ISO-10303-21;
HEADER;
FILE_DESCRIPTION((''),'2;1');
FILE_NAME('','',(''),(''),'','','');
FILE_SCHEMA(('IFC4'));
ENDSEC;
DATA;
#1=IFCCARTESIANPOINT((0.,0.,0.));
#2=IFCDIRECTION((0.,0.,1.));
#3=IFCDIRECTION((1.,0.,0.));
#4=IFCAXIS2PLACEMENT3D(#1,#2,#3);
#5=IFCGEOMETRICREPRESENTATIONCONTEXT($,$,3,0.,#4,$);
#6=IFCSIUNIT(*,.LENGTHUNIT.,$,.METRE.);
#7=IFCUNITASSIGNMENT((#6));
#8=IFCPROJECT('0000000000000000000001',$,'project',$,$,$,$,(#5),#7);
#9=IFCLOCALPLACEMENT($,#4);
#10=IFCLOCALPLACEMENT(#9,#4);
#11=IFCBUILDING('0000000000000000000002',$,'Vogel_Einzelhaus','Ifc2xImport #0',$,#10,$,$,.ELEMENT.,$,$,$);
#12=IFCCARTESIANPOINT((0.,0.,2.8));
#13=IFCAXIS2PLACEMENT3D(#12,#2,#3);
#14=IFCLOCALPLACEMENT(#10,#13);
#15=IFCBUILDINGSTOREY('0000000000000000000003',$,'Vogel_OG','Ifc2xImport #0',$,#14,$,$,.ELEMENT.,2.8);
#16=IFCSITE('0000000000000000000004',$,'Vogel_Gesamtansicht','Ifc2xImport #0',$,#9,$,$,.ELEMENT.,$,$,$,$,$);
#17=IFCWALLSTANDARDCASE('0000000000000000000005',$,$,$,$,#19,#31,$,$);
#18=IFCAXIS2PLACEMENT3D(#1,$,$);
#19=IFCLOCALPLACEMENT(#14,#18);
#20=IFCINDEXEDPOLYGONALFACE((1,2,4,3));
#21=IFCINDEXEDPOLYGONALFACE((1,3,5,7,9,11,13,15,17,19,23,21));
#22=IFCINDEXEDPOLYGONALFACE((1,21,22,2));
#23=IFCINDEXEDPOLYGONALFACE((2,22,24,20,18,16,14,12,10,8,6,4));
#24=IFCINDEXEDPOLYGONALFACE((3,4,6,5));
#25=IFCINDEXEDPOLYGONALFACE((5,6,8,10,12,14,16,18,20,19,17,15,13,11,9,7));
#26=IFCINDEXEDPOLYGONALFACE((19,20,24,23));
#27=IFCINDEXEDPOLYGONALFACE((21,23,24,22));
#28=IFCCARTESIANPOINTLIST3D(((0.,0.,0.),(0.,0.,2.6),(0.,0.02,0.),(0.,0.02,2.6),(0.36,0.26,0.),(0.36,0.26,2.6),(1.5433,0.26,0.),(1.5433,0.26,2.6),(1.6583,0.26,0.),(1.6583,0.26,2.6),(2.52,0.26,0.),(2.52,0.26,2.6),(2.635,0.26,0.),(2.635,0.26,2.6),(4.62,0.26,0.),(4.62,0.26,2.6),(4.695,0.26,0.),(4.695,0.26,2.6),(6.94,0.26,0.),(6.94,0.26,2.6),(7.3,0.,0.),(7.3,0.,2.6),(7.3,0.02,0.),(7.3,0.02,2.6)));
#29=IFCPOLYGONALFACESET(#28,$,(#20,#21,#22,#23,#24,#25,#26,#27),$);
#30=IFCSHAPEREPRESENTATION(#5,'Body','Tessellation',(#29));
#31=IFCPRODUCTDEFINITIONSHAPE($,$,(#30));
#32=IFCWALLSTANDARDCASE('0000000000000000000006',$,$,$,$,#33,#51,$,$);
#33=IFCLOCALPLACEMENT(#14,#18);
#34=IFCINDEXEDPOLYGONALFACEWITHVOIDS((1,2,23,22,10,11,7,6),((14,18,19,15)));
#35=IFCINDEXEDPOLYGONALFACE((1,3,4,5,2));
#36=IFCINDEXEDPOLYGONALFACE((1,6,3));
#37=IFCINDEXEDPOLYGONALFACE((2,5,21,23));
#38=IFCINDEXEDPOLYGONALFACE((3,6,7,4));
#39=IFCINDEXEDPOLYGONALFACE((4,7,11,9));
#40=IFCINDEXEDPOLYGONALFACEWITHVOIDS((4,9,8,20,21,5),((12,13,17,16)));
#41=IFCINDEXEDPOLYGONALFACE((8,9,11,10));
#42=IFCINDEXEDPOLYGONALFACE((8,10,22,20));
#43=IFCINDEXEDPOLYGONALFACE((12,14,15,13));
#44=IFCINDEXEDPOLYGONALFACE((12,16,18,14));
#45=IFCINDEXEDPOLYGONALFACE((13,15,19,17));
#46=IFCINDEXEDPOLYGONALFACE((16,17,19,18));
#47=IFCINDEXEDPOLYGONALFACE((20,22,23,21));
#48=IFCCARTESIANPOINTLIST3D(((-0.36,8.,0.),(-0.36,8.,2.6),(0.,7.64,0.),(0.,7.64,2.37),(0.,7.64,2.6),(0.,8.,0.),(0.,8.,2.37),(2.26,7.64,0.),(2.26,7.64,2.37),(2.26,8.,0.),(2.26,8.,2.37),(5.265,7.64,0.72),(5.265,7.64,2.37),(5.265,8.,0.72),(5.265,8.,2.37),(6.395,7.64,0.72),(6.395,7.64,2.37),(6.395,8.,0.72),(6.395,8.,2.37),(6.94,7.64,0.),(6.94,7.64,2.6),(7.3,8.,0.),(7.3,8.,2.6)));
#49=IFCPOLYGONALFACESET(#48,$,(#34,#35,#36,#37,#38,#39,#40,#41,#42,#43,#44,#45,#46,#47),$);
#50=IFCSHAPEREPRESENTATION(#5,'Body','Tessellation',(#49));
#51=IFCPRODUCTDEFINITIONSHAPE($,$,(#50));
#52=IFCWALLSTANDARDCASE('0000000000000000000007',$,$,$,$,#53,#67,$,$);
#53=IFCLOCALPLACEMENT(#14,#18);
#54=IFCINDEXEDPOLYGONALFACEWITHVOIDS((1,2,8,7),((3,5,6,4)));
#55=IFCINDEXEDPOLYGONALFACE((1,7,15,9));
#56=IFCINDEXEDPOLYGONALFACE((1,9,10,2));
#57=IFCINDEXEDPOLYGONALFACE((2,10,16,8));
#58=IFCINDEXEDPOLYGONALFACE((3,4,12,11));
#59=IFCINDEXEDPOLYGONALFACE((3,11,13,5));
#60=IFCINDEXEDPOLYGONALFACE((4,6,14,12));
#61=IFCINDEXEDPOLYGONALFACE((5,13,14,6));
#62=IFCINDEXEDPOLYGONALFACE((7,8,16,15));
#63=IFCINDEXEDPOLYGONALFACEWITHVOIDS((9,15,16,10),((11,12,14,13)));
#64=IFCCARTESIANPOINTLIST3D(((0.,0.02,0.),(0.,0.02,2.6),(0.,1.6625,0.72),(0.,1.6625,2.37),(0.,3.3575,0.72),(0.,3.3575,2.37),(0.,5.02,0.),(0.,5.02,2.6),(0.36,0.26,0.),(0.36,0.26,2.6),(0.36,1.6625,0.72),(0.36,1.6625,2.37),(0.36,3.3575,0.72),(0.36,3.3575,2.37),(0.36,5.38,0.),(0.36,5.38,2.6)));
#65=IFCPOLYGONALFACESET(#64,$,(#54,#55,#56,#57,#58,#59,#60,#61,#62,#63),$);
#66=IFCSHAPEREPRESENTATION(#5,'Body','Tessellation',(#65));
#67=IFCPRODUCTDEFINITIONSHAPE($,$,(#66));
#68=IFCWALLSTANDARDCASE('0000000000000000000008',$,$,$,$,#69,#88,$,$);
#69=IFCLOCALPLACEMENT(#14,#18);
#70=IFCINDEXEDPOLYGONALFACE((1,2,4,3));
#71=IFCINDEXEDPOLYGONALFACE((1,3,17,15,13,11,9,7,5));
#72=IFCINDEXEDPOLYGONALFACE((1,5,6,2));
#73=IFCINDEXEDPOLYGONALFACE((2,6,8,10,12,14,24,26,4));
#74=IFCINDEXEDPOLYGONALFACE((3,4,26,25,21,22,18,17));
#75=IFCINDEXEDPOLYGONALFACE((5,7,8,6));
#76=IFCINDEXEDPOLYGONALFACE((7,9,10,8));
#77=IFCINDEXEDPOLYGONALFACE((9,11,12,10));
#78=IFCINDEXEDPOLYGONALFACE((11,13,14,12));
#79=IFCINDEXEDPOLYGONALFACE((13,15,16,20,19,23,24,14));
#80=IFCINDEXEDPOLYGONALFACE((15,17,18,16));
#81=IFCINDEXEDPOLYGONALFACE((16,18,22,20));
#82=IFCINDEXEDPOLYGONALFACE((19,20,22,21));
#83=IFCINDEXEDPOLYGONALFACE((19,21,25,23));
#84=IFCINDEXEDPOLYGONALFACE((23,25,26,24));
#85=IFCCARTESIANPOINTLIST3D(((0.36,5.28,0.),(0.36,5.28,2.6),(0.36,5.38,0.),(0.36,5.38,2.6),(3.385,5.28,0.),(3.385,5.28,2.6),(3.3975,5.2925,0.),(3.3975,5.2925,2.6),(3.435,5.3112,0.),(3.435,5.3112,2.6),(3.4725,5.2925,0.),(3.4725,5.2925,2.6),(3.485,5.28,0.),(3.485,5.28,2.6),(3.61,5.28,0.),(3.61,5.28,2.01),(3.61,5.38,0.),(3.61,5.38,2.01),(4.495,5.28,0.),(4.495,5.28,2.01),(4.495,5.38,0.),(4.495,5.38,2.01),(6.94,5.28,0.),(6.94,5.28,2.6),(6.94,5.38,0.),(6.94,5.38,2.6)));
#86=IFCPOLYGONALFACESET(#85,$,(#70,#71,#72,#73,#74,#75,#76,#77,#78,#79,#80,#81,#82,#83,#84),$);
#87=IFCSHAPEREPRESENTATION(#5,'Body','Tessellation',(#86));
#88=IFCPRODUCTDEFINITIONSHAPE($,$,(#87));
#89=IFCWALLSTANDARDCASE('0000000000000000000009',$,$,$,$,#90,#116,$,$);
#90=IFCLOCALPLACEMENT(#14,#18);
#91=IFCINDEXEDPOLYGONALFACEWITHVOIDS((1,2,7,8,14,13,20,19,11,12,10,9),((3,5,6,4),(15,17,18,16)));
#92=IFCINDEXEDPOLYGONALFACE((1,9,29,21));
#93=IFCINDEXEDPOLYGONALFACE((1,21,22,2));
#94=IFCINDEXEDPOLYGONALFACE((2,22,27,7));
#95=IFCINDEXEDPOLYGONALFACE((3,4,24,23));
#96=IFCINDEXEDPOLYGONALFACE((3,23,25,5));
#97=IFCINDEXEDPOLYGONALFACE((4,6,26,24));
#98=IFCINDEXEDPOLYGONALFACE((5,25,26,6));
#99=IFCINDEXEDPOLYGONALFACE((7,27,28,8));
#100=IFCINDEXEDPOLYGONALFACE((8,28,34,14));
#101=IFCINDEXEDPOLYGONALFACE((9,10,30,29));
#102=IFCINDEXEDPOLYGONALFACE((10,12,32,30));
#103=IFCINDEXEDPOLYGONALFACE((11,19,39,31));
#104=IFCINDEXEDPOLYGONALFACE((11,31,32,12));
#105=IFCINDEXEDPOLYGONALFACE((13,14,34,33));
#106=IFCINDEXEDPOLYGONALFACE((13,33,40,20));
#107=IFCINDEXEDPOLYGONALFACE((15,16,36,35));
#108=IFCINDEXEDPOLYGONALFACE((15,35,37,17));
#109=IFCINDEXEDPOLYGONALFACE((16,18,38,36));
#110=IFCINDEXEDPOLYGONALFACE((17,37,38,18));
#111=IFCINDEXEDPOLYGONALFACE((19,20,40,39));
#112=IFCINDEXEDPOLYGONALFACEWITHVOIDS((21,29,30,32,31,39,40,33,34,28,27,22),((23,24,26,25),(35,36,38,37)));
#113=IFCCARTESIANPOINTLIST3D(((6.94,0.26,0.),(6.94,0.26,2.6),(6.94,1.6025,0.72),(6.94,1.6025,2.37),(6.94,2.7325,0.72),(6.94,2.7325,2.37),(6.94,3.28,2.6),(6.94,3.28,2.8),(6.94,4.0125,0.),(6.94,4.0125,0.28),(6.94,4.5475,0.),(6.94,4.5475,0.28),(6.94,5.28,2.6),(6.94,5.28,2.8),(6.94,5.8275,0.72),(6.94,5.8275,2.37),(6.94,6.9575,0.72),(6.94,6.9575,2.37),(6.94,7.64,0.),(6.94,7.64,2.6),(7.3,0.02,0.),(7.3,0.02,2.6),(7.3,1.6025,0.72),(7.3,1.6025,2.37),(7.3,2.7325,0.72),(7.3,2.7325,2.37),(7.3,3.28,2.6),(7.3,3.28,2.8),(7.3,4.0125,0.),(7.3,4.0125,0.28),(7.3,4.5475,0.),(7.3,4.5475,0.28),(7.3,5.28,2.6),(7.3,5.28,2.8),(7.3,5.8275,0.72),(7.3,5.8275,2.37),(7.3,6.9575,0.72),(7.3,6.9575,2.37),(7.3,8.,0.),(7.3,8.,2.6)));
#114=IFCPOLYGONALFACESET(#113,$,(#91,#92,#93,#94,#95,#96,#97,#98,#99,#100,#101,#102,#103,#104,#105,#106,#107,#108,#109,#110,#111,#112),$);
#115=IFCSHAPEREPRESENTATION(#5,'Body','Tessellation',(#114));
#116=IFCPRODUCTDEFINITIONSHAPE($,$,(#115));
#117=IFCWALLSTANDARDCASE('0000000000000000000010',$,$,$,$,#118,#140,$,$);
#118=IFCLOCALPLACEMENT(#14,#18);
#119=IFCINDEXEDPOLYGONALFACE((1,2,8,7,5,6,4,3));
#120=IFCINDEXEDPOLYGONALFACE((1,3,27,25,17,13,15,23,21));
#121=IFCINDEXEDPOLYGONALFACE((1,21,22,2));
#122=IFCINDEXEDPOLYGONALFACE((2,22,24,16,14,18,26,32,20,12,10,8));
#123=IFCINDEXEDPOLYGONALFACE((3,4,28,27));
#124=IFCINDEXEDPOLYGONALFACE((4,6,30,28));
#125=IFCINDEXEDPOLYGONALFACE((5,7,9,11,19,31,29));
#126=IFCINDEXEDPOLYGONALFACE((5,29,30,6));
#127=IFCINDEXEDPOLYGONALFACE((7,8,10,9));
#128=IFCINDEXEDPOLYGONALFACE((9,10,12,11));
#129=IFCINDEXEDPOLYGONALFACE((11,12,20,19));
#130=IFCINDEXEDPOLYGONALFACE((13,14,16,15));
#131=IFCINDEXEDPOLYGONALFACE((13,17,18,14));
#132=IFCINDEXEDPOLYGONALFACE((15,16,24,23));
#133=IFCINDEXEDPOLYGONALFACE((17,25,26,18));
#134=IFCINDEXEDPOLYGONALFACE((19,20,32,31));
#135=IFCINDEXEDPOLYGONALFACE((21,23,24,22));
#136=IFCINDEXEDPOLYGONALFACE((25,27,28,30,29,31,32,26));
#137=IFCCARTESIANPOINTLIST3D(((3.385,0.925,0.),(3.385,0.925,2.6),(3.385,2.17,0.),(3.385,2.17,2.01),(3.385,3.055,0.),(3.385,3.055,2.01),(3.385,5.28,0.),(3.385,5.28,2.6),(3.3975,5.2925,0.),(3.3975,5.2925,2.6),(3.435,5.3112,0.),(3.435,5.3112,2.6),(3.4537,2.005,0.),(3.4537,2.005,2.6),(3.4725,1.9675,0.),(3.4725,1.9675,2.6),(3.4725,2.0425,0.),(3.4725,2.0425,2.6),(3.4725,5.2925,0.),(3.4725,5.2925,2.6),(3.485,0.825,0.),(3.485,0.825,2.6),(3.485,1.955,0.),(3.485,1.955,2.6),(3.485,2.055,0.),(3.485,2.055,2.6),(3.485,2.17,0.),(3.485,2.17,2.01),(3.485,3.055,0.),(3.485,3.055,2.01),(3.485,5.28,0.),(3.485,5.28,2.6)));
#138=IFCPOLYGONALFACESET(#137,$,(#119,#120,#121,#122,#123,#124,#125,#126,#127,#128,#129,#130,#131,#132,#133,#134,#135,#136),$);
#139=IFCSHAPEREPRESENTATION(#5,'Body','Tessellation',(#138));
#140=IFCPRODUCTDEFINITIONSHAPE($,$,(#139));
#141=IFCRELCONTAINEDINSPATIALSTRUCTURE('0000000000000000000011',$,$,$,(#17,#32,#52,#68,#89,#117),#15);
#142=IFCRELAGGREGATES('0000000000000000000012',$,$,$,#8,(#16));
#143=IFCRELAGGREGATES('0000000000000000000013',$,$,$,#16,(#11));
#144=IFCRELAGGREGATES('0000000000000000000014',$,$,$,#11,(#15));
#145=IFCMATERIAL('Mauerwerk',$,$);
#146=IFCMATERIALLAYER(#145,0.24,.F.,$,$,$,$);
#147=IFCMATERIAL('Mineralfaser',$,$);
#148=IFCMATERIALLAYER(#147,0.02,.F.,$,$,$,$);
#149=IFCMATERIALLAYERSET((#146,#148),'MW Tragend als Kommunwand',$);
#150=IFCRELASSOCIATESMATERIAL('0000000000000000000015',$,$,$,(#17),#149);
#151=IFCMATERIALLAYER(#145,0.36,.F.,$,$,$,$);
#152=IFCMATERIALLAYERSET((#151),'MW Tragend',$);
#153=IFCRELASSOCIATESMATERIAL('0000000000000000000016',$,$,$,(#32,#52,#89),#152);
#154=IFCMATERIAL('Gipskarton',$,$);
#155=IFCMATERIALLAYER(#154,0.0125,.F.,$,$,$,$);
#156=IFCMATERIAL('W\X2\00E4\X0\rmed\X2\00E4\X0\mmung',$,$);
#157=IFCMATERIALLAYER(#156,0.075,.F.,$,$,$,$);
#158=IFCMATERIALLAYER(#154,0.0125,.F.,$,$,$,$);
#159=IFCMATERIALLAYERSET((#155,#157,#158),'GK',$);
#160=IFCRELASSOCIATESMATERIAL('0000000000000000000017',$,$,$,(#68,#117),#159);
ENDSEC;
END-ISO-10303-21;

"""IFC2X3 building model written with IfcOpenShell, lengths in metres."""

from ifc_helpers import new_model, si_unit, frame, origin_with_axes, origin_2d_with_axis, place, context, project, spatial, polyline, rectangle, outline, extrude, clip, bounded_halfspace, shape, material, layer, layer_set, layer_usage, element, save


model = new_model("IFC2X3")

# Units and contexts
context_of_model = context(None, 3, precision=0.0, world=origin_with_axes())
ifc_project = project(units=[si_unit("LENGTHUNIT", "METRE")], contexts=[context_of_model])

# Site, building, storey
site_placement = place(None, origin_with_axes())
site = spatial("IfcSite", under=ifc_project, at=site_placement, Name="Vogel_Gesamtansicht", Description="Ifc2xImport #0", CompositionType="ELEMENT")
building_placement = place(site_placement, origin_with_axes())
building = spatial("IfcBuilding", under=site, at=building_placement, Name="Vogel_Einzelhaus", Description="Ifc2xImport #0", CompositionType="ELEMENT")
storey_placement = place(building_placement, frame((0.0, 0.0, 2.8), z_axis=(0.0, 0.0, 1.0), x_axis=(1.0, 0.0, 0.0)))
storey = spatial("IfcBuildingStorey", under=building, at=storey_placement, Name="Vogel_OG", Description="Ifc2xImport #0", CompositionType="ELEMENT", Elevation=2.8)

# Wall
ifc_material_1 = material(Name="Mauerwerk")
ifc_layer_1 = layer(ifc_material_1, 0.24, ventilated=False)
ifc_material_2 = material(Name="Mineralfaser")
ifc_layer_2 = layer(ifc_material_2, 0.02, ventilated=False)
ifc_layer_set_1 = layer_set([ifc_layer_1, ifc_layer_2], Name="MW Tragend als Kommunwand")
ifc_layer_usage_1 = layer_usage(ifc_layer_set_1, "AXIS2", "POSITIVE", -0.26)
wall_1_placement = place(storey_placement, frame((7.3, 0.0, 0.0), z_axis=(0.0, 0.0, 1.0), x_axis=(-1.0, 0.0, 0.0)))
element("IfcWallStandardCase", 1, at=wall_1_placement, inside=storey, material=ifc_layer_usage_1, context=context_of_model, shape_type="SweptSolid", body=[
    extrude(outline(polyline([(0.0, -0.02), (0.36, -0.26), (2.605, -0.26), (2.68, -0.26), (4.665, -0.26), (4.78, -0.26), (5.6417, -0.26), (5.7567, -0.26), (6.94, -0.26), (7.3, -0.02), (7.3, 0.0), (0.0, 0.0), (0.0, -0.02)])), origin_with_axes(), (0.0, 0.0, 1.0), 2.6),
])

# Wall, openings
ifc_layer_3 = layer(ifc_material_1, 0.36, ventilated=False)
ifc_layer_set_2 = layer_set([ifc_layer_3], Name="MW Tragend")
ifc_layer_usage_2 = layer_usage(ifc_layer_set_2, "AXIS2", "POSITIVE", -0.36)
wall_2_placement = place(storey_placement, frame((-0.18, 8.0, 0.0), z_axis=(0.0, 0.0, 1.0), x_axis=(1.0, 0.0, 0.0)))
wall_2 = element("IfcWallStandardCase", 2, at=wall_2_placement, inside=storey, material=ifc_layer_usage_2, context=context_of_model, shape_type="SweptSolid", body=[
    extrude(outline(polyline([(-0.18, 0.0), (0.18, -0.36), (7.12, -0.36), (7.48, 0.0), (-0.18, 0.0)])), origin_with_axes(), (0.0, 0.0, 1.0), 2.6),
])
opening_1_placement = place(wall_2_placement, frame((0.18, 0.0, 0.0), z_axis=(1.0, 0.0, 0.0), x_axis=(0.0, 0.0, 1.0)))
element("IfcOpeningElement", 3, at=opening_1_placement, cuts=wall_2, shapes=[
    shape(context_of_model, None, "SweptSolid", [extrude(rectangle(XDim=2.37, YDim=2.26, at=origin_2d_with_axis()), frame((1.185, 0.0, 1.13), z_axis=(0.0, 1.0, 0.0), x_axis=(1.0, 0.0, 0.0)), (0.0, 0.0, 1.0), 0.36)]),
])
opening_2_placement = place(wall_2_placement, frame((6.575, -0.36, 0.72), z_axis=(-1.0, 0.0, 0.0), x_axis=(0.0, 0.0, 1.0)))
element("IfcOpeningElement", 4, at=opening_2_placement, cuts=wall_2, shapes=[
    shape(context_of_model, None, "SweptSolid", [extrude(rectangle(XDim=1.65, YDim=1.13, at=origin_2d_with_axis()), frame((0.825, 0.0, 0.565), z_axis=(0.0, 1.0, 0.0), x_axis=(1.0, 0.0, 0.0)), (0.0, 0.0, 1.0), 0.36)]),
])

# Wall, opening
wall_3_placement = place(storey_placement, frame((0.0, 0.0, 0.0), z_axis=(0.0, 0.0, 1.0), x_axis=(0.0, 1.0, 0.0)))
wall_3 = element("IfcWallStandardCase", 5, at=wall_3_placement, inside=storey, material=ifc_layer_usage_2, context=context_of_model, shape_type="SweptSolid", body=[
    extrude(outline(polyline([(5.38, -0.36), (5.02, 0.0), (0.02, 0.0), (0.26, -0.36), (5.28, -0.36), (5.38, -0.36)])), origin_with_axes(), (0.0, 0.0, 1.0), 2.6),
])
opening_3_placement = place(wall_3_placement, frame((1.6625, 0.0, 0.72), z_axis=(1.0, 0.0, 0.0), x_axis=(0.0, 0.0, 1.0)))
element("IfcOpeningElement", 6, at=opening_3_placement, cuts=wall_3, shapes=[
    shape(context_of_model, None, "SweptSolid", [extrude(rectangle(XDim=1.65, YDim=1.695, at=origin_2d_with_axis()), frame((0.825, 0.0, 0.8475), z_axis=(0.0, 1.0, 0.0), x_axis=(1.0, 0.0, 0.0)), (0.0, 0.0, 1.0), 0.36)]),
])

# Shared definitions
ifc_material_3 = material(Name="Gipskarton")
ifc_layer_4 = layer(ifc_material_3, 0.0125, ventilated=False)
ifc_material_4 = material(Name="Wärmedämmung")
ifc_layer_5 = layer(ifc_material_4, 0.075, ventilated=False)
ifc_layer_6 = layer(ifc_material_3, 0.0125, ventilated=False)
ifc_layer_set_3 = layer_set([ifc_layer_4, ifc_layer_5, ifc_layer_6], Name="GK")
ifc_layer_usage_3 = layer_usage(ifc_layer_set_3, "AXIS2", "POSITIVE", -0.1)

# Wall, opening
ifc_layer_usage_4 = layer_usage(ifc_layer_set_3, "AXIS2", "POSITIVE", 0.0)
wall_4_placement = place(storey_placement, frame((0.36, 5.28, 0.0), z_axis=(0.0, 0.0, 1.0), x_axis=(1.0, 0.0, 0.0)))
wall_4 = element("IfcWallStandardCase", 7, at=wall_4_placement, inside=storey, material=ifc_layer_usage_4, context=context_of_model, shape_type="SweptSolid", body=[
    extrude(outline(polyline([(3.025, 0.0), (3.0375, 0.0125), (3.075, 0.0313), (3.1125, 0.0125), (3.125, 0.0), (6.58, 0.0), (6.58, 0.1), (0.0, 0.1), (0.0, 0.0), (3.025, 0.0)])), origin_with_axes(), (0.0, 0.0, 1.0), 2.6),
])
opening_4_placement = place(wall_4_placement, frame((3.25, 0.1, 0.0), z_axis=(1.0, 0.0, 0.0), x_axis=(0.0, 0.0, 1.0)))
element("IfcOpeningElement", 8, at=opening_4_placement, cuts=wall_4, shapes=[
    shape(context_of_model, None, "SweptSolid", [extrude(rectangle(XDim=2.01, YDim=0.885, at=origin_2d_with_axis()), frame((1.005, 0.0, 0.4425), z_axis=(0.0, 1.0, 0.0), x_axis=(1.0, 0.0, 0.0)), (0.0, 0.0, 1.0), 0.1)]),
])

# Wall, openings
wall_5_placement = place(storey_placement, frame((7.3, 8.0, 0.0), z_axis=(0.0, 0.0, 1.0), x_axis=(0.0, -1.0, 0.0)))
wall_5 = element("IfcWallStandardCase", 9, at=wall_5_placement, inside=storey, material=ifc_layer_usage_2, context=context_of_model, shape_type="Clipping", body=[
    clip(clip(clip(clip(clip(clip(extrude(outline(polyline([(4.77, -0.36), (4.82, -0.36), (7.54, -0.36), (7.74, -0.36), (7.98, 0.0), (4.77, 0.0), (2.67, 0.0), (0.0, 0.0), (0.36, -0.36), (2.62, -0.36), (2.67, -0.36), (2.72, -0.36), (4.72, -0.36), (4.77, -0.36)])), origin_with_axes(), (0.0, 0.0, 1.0), 2.8), bounded_halfspace(frame((0.0, 0.0, 2.6), z_axis=(0.0, 0.0, -1.0), x_axis=(1.0, 0.0, 0.0)), True, origin_with_axes(), polyline([(-7.74, -0.36), (2.72, -0.36), (2.72, 0.36), (-7.74, 0.36), (-7.74, -0.36)]))), bounded_halfspace(frame((2.72, 0.0, 2.8), z_axis=(0.0, 0.0, -1.0), x_axis=(1.0, 0.0, 0.0)), True, origin_with_axes(), polyline([(2.72, -0.36), (4.72, -0.36), (4.72, 0.36), (2.72, 0.36), (2.72, -0.36)]))), bounded_halfspace(frame((4.72, 0.0, 2.6), z_axis=(0.0, 0.0, -1.0), x_axis=(1.0, 0.0, 0.0)), True, origin_with_axes(), polyline([(4.72, -0.36), (15.48, -0.36), (15.48, 0.36), (4.72, 0.36), (4.72, -0.36)]))), bounded_halfspace(origin_with_axes(), True, origin_with_axes(), polyline([(-7.74, -0.36), (3.4525, -0.36), (3.4525, 0.36), (-7.74, 0.36), (-7.74, -0.36)]))), bounded_halfspace(frame((3.4525, 0.0, 0.28), z_axis=(0.0, 0.0, 1.0), x_axis=(1.0, 0.0, 0.0)), True, origin_with_axes(), polyline([(3.4525, -0.36), (3.9875, -0.36), (3.9875, 0.36), (3.4525, 0.36), (3.4525, -0.36)]))), bounded_halfspace(frame((3.9875, 0.0, 0.0), z_axis=(0.0, 0.0, 1.0), x_axis=(1.0, 0.0, 0.0)), True, origin_with_axes(), polyline([(3.9875, -0.36), (15.48, -0.36), (15.48, 0.36), (3.9875, 0.36), (3.9875, -0.36)]))),
])
opening_5_placement = place(wall_5_placement, frame((1.0425, 0.0, 0.72), z_axis=(1.0, 0.0, 0.0), x_axis=(0.0, 0.0, 1.0)))
element("IfcOpeningElement", 10, at=opening_5_placement, cuts=wall_5, shapes=[
    shape(context_of_model, None, "SweptSolid", [extrude(rectangle(XDim=1.65, YDim=1.13, at=origin_2d_with_axis()), frame((0.825, 0.0, 0.565), z_axis=(0.0, 1.0, 0.0), x_axis=(1.0, 0.0, 0.0)), (0.0, 0.0, 1.0), 0.36)]),
])
opening_6_placement = place(wall_5_placement, frame((6.3975, -0.36, 0.72), z_axis=(-1.0, 0.0, 0.0), x_axis=(0.0, 0.0, 1.0)))
element("IfcOpeningElement", 11, at=opening_6_placement, cuts=wall_5, shapes=[
    shape(context_of_model, None, "SweptSolid", [extrude(rectangle(XDim=1.65, YDim=1.13, at=origin_2d_with_axis()), frame((0.825, 0.0, 0.565), z_axis=(0.0, 1.0, 0.0), x_axis=(1.0, 0.0, 0.0)), (0.0, 0.0, 1.0), 0.36)]),
])

# Wall, opening
wall_6_placement = place(storey_placement, frame((3.485, 5.28, 0.0), z_axis=(0.0, 0.0, 1.0), x_axis=(0.0, -1.0, 0.0)))
wall_6 = element("IfcWallStandardCase", 12, at=wall_6_placement, inside=storey, material=ifc_layer_usage_3, context=context_of_model, shape_type="SweptSolid", body=[
    extrude(outline(polyline([(-0.0125, -0.0875), (0.0, -0.1), (4.355, -0.1), (4.455, 0.0), (3.325, 0.0), (3.3125, -0.0125), (3.275, -0.0312), (3.2375, -0.0125), (3.225, 0.0), (0.0, 0.0), (-0.0125, -0.0125), (-0.0313, -0.05), (-0.0125, -0.0875)])), origin_with_axes(), (0.0, 0.0, 1.0), 2.6),
])
opening_7_placement = place(wall_6_placement, frame((2.225, 0.0, 0.0), z_axis=(1.0, 0.0, 0.0), x_axis=(0.0, 0.0, 1.0)))
element("IfcOpeningElement", 13, at=opening_7_placement, cuts=wall_6, shapes=[
    shape(context_of_model, None, "SweptSolid", [extrude(rectangle(XDim=2.01, YDim=0.885, at=origin_2d_with_axis()), frame((1.005, 0.0, 0.4425), z_axis=(0.0, 1.0, 0.0), x_axis=(1.0, 0.0, 0.0)), (0.0, 0.0, 1.0), 0.1)]),
])

save(model, "model.ifc")
